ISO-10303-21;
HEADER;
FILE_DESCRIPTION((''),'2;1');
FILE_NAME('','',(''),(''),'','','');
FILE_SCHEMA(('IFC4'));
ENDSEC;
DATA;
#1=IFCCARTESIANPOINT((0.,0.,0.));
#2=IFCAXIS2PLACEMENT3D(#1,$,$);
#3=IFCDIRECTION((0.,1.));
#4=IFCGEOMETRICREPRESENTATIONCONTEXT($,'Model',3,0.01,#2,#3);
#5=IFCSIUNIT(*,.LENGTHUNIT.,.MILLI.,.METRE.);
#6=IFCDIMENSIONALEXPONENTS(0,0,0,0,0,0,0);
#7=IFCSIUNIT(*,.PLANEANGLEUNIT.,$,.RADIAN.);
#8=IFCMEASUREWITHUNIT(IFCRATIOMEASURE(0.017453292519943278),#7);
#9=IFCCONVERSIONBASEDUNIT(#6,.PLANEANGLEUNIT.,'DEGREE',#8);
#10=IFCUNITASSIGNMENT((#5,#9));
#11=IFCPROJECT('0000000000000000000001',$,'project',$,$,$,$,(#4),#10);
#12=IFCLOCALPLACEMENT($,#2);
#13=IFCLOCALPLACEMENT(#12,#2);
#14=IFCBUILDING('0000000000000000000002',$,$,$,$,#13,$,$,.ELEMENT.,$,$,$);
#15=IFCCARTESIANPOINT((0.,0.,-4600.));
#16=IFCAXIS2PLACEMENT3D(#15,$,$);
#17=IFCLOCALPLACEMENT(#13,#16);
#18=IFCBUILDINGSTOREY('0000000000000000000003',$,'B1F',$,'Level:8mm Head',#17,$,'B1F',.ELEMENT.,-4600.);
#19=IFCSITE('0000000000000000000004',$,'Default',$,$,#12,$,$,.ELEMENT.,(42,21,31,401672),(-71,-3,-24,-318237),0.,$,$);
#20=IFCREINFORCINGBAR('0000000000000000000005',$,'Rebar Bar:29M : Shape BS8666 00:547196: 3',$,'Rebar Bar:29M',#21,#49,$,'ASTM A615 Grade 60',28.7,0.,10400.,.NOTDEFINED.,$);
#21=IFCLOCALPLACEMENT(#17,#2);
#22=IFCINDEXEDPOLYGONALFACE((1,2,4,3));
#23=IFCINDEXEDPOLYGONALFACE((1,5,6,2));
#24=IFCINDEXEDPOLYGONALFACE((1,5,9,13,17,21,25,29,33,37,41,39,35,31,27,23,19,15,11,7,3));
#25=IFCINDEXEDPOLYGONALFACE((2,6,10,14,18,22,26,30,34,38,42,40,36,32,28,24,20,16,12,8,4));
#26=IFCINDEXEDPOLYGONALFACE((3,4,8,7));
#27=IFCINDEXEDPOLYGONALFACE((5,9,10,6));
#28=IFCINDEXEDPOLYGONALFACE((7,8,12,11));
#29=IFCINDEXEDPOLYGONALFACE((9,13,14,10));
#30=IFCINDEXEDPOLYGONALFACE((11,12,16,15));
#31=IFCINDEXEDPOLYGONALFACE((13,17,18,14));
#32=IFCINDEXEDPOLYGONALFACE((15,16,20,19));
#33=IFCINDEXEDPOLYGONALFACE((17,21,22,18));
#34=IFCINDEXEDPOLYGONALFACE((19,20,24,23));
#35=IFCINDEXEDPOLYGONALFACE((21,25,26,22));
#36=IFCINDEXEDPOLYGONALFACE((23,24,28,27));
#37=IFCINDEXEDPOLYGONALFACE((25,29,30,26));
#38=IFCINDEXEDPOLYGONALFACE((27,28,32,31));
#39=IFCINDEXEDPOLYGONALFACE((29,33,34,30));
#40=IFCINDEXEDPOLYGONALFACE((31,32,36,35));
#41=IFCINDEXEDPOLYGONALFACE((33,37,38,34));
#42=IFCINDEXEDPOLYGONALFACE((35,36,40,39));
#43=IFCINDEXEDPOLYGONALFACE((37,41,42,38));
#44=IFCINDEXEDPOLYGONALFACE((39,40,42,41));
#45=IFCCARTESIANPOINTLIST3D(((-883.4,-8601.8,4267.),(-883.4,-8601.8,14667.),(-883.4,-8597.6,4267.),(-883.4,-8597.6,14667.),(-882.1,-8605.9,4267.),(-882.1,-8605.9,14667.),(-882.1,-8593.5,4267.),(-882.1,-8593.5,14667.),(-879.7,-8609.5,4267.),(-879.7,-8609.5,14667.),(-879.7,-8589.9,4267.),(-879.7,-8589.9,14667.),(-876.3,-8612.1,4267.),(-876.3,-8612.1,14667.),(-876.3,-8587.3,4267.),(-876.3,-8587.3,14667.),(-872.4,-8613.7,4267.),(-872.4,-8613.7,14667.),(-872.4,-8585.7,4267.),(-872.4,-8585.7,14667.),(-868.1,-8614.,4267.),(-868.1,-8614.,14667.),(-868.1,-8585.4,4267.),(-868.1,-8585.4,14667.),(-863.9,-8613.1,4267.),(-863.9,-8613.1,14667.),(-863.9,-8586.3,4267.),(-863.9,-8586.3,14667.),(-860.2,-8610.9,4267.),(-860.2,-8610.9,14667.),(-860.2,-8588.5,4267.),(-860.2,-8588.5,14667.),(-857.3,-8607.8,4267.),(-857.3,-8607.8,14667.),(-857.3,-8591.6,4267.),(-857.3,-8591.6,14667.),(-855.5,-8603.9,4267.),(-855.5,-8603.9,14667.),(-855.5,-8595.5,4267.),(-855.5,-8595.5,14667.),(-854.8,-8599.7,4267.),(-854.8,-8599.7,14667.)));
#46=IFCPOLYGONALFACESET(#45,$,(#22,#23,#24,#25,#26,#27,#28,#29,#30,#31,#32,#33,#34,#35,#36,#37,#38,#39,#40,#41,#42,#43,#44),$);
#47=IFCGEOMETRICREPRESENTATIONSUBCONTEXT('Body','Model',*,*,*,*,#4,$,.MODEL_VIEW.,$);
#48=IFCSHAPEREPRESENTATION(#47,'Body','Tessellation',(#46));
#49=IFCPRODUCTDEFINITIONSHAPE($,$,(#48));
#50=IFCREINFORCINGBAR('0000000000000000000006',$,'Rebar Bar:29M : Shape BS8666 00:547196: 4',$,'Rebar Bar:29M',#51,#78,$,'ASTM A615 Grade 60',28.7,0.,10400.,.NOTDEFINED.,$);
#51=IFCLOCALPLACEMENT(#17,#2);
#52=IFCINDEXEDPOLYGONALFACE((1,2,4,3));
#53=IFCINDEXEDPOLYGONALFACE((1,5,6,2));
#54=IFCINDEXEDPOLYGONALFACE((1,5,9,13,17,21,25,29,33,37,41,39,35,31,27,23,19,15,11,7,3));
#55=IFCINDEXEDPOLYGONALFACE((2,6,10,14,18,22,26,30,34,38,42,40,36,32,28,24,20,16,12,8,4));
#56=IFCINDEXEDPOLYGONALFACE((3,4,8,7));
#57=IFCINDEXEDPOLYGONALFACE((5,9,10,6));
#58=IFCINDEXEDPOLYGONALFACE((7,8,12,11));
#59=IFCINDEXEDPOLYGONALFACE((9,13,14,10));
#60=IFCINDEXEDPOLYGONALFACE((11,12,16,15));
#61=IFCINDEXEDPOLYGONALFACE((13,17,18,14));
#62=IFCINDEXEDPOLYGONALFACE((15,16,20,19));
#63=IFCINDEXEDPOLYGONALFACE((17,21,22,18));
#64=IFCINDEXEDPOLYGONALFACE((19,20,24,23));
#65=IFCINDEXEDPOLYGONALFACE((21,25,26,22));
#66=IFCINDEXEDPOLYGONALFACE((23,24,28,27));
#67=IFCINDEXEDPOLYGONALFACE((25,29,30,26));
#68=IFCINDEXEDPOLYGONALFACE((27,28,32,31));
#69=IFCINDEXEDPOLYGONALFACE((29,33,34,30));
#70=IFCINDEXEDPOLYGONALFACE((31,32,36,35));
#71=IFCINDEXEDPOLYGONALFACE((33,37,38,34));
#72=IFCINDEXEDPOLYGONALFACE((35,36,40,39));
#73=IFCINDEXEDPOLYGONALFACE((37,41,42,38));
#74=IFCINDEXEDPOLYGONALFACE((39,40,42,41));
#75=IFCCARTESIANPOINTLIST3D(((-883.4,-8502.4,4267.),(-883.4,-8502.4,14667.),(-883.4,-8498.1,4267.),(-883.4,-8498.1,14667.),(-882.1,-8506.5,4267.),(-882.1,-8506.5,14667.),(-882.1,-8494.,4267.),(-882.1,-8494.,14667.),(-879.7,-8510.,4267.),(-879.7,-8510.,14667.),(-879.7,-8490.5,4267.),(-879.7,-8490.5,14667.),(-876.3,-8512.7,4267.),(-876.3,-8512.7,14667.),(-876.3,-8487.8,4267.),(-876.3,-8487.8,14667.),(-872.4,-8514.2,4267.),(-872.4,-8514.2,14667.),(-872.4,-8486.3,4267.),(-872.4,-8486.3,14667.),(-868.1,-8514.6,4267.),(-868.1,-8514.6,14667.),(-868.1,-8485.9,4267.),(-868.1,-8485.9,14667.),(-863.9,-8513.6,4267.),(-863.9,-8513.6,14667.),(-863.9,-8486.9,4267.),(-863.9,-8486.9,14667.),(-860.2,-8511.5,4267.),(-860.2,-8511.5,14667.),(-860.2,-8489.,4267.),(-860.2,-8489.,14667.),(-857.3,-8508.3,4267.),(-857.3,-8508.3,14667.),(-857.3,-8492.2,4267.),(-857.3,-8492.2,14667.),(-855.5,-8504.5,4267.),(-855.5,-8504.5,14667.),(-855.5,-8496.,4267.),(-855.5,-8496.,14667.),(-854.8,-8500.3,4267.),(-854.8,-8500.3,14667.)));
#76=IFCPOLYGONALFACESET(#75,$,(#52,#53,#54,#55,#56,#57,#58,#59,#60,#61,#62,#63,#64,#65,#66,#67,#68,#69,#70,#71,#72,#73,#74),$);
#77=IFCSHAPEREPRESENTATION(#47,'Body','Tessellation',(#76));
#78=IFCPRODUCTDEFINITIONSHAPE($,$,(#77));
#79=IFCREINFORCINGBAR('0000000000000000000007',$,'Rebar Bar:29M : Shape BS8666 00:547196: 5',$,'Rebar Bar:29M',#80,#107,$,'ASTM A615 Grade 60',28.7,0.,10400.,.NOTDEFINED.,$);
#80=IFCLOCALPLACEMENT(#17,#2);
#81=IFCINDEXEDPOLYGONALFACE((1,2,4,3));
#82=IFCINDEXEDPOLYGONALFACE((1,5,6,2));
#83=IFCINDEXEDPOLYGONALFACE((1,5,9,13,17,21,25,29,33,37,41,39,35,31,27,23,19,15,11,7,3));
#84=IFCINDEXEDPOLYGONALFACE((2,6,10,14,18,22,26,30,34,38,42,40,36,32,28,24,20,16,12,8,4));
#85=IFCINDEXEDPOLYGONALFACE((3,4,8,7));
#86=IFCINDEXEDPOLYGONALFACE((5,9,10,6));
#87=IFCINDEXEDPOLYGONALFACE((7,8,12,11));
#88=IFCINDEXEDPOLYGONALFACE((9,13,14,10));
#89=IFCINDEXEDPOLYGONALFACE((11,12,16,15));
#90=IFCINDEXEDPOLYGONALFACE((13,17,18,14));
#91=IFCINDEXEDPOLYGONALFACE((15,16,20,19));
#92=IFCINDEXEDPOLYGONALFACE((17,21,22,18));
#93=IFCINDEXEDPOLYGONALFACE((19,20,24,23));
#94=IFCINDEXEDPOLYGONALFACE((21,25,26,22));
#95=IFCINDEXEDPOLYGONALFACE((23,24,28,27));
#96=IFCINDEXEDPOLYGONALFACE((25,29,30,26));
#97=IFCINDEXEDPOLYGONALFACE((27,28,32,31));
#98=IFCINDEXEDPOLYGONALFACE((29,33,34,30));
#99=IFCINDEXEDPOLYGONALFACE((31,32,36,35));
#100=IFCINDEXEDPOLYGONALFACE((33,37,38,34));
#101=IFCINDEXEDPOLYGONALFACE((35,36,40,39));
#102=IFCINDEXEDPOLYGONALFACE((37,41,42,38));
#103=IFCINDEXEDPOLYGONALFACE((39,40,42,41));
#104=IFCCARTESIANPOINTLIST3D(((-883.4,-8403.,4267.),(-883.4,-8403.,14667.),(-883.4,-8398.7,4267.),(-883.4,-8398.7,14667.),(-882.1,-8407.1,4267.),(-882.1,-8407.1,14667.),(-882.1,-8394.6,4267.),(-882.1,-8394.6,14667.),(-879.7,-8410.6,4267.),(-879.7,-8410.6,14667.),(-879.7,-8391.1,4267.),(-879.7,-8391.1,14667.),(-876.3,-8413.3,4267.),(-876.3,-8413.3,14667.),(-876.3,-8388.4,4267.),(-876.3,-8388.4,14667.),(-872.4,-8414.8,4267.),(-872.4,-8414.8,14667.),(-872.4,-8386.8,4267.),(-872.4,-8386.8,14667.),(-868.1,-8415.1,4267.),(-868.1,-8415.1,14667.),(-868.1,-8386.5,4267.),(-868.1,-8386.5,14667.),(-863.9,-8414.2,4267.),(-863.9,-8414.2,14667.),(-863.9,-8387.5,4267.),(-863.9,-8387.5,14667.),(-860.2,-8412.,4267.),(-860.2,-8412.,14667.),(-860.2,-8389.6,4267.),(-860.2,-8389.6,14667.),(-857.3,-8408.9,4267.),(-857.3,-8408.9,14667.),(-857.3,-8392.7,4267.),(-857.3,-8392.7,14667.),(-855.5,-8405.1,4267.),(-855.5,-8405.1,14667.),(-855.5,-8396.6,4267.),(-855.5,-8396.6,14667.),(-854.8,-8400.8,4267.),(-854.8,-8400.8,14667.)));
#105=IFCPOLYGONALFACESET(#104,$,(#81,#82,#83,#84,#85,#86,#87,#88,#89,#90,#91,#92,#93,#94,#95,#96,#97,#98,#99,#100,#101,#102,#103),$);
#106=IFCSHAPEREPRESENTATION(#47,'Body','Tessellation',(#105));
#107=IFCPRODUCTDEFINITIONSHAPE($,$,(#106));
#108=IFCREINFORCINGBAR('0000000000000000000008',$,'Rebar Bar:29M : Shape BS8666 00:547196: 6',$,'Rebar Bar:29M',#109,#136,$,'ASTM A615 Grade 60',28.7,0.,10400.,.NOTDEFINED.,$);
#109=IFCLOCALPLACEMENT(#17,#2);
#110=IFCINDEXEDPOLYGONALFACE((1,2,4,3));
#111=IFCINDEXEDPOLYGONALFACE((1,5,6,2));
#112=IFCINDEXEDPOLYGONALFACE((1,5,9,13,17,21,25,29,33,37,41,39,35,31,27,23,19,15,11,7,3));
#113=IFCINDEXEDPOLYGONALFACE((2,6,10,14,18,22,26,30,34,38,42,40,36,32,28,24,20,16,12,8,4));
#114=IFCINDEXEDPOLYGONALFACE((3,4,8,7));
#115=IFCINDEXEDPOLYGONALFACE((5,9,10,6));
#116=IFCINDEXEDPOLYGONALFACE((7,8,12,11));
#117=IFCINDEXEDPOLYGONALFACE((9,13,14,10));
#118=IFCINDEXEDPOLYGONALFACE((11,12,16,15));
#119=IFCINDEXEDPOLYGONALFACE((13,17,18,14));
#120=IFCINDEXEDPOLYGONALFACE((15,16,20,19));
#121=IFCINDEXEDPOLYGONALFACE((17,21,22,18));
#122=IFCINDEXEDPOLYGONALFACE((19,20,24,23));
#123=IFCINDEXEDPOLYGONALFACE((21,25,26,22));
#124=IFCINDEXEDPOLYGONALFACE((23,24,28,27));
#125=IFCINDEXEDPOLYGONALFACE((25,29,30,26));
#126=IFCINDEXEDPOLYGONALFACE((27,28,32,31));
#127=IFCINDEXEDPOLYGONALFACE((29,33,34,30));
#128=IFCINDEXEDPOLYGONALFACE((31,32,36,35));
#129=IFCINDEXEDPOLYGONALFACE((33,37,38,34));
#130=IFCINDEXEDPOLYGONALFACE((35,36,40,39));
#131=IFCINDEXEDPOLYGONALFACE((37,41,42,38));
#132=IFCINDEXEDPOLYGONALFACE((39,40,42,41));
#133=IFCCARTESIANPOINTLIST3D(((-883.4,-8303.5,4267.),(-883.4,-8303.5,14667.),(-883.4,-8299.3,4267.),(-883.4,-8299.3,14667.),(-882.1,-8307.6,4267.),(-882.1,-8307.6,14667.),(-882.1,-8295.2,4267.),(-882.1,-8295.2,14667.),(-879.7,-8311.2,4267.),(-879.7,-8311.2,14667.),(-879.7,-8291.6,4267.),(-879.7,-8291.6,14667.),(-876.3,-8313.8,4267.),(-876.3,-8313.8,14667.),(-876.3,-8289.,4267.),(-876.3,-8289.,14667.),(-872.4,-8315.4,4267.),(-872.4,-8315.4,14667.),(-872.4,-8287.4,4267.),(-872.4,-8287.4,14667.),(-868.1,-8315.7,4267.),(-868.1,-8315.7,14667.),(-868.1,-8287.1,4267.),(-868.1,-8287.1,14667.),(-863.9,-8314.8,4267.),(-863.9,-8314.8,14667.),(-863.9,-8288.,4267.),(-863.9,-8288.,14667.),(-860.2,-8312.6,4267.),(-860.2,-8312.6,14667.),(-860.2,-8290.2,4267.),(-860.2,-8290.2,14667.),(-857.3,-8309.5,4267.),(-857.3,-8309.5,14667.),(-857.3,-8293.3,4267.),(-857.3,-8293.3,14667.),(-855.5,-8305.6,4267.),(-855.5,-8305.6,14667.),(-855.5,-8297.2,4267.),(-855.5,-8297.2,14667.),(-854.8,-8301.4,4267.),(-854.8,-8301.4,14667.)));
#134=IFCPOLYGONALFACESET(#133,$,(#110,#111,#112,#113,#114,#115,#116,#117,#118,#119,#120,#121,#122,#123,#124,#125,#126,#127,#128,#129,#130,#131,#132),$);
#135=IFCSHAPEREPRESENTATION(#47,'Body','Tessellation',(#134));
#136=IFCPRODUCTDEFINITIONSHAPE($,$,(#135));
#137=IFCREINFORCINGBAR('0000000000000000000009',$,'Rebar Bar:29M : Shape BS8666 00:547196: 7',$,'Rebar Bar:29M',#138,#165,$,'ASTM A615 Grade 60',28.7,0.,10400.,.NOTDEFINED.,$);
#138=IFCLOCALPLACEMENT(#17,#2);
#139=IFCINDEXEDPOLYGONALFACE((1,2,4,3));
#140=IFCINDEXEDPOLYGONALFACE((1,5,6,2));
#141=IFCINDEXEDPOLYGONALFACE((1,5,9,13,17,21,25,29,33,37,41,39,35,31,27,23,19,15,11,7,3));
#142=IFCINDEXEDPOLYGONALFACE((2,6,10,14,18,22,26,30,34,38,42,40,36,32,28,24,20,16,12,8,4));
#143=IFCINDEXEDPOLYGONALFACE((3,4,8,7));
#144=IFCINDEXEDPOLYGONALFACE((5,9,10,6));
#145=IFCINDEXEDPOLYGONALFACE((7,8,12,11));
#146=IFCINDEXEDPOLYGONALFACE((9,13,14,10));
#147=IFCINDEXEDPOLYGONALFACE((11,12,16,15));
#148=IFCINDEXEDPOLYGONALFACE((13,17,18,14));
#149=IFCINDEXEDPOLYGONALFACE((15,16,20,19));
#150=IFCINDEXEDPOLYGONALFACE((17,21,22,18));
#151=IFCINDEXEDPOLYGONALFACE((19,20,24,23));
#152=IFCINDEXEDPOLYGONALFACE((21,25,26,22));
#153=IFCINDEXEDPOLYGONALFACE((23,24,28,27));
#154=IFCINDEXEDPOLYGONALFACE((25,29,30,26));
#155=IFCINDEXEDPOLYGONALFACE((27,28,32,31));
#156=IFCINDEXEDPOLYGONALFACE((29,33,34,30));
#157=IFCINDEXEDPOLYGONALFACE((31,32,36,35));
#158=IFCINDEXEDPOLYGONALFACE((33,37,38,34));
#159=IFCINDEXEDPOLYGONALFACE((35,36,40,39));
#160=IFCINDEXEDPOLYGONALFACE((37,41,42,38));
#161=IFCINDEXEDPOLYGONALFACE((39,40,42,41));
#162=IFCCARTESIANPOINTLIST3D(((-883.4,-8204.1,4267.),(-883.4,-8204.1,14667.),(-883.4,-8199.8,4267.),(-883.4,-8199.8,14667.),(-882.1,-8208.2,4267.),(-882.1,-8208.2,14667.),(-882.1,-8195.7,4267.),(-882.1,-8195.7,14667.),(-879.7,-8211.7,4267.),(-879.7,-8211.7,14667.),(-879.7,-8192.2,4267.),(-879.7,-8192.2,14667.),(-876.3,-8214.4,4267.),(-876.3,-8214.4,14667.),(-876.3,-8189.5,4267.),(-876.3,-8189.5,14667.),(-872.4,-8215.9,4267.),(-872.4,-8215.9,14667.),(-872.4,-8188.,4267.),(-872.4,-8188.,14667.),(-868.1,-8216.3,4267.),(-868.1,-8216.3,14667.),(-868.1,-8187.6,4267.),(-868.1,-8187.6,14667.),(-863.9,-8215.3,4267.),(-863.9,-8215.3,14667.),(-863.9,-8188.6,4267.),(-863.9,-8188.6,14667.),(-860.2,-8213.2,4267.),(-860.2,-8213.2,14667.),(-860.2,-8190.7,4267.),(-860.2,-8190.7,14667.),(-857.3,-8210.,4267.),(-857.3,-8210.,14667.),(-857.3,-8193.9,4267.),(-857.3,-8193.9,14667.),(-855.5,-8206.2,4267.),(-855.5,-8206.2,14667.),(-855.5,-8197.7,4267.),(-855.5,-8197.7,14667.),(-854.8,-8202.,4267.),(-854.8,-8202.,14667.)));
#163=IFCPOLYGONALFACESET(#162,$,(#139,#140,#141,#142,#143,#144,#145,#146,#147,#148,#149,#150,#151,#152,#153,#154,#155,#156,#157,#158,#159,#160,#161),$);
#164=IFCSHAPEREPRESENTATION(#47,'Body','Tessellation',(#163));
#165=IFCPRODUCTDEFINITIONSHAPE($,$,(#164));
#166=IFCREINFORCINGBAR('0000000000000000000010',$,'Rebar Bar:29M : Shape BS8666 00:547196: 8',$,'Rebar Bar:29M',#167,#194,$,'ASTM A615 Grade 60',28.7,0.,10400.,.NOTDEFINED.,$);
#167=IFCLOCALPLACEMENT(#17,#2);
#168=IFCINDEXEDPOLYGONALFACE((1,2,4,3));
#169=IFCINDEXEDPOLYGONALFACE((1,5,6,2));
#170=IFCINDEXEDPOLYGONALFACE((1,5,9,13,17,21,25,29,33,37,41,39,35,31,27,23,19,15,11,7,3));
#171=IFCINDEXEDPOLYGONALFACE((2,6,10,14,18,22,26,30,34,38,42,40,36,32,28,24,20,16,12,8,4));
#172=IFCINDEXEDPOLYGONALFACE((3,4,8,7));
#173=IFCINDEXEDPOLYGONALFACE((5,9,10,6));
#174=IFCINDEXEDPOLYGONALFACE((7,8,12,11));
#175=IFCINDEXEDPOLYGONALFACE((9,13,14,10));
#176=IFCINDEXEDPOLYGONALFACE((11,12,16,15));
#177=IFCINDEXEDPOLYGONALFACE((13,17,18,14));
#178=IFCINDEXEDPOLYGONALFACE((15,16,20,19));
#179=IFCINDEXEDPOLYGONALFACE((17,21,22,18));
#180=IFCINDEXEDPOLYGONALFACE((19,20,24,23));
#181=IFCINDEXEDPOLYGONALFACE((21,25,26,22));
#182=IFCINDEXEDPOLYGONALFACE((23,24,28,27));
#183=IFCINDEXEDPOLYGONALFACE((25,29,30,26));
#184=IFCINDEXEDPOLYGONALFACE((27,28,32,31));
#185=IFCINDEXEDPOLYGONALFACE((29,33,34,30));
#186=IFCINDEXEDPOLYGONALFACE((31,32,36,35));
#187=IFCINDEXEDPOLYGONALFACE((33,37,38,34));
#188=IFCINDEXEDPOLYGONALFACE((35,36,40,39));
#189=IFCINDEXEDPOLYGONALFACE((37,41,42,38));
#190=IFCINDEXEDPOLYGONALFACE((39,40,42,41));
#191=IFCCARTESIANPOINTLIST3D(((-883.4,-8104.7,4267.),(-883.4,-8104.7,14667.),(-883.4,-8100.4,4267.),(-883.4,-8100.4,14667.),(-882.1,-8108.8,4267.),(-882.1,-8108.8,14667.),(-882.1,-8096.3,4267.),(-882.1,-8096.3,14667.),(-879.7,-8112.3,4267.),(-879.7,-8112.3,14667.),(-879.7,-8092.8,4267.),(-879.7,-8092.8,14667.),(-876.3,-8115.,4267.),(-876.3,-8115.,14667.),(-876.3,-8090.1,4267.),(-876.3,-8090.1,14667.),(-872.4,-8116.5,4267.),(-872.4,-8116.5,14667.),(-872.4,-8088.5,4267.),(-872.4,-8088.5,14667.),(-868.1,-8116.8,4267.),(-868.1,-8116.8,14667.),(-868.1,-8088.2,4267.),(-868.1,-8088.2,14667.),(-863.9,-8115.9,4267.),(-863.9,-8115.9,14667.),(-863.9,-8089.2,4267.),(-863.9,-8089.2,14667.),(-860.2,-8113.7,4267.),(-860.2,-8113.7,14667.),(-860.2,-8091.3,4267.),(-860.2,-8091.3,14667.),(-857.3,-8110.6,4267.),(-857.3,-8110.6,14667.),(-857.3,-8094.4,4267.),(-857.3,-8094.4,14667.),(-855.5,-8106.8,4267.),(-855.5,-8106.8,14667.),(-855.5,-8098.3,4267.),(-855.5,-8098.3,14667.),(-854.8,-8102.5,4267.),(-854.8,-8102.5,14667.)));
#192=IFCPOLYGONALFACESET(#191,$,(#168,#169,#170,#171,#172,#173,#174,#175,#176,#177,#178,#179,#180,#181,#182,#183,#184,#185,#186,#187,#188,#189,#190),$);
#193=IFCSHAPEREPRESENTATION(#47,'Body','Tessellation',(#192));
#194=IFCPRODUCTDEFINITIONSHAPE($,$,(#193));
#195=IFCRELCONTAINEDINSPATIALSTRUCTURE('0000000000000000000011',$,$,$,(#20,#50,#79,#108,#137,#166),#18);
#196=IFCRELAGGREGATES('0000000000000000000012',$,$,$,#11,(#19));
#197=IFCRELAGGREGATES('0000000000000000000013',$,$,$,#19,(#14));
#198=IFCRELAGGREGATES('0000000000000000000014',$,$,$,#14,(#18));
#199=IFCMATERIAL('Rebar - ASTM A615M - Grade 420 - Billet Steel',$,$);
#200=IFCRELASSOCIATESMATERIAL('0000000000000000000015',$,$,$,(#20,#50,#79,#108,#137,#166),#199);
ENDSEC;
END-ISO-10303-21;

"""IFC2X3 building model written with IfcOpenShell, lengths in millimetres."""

from ifc_helpers import new_model, entity, si_unit, converted_unit, direction, frame, origin, place, context, subcontext, project, spatial, material, element, save


model = new_model("IFC2X3")

# Units and contexts
model_context = context("Model", 3, precision=0.01, world=origin(), true_north=direction((0.0, 1.0)))
body_context = subcontext(model_context, "Body", "Model", "MODEL_VIEW")
ifc_project = project(units=[si_unit("LENGTHUNIT", "METRE", prefix="MILLI"), converted_unit("PLANEANGLEUNIT", "DEGREE", entity("IfcRatioMeasure", 0.017453292519943278), si_unit("PLANEANGLEUNIT", "RADIAN"), dimensions=[0, 0, 0, 0, 0, 0, 0])], contexts=[model_context])

# Site, building, storey
site_placement = place(None, origin())
site = spatial("IfcSite", under=ifc_project, at=site_placement, Name="Default", CompositionType="ELEMENT", RefLatitude=(42, 21, 31, 401672), RefLongitude=(-71, -3, -24, -318237), RefElevation=0.0)
building_placement = place(site_placement, origin())
building = spatial("IfcBuilding", under=site, at=building_placement, CompositionType="ELEMENT")
storey_placement = place(building_placement, frame((0.0, 0.0, -4600.0)))
storey = spatial("IfcBuildingStorey", under=building, at=storey_placement, Name="B1F", ObjectType="Level:8mm Head", LongName="B1F", CompositionType="ELEMENT", Elevation=-4600.0)

# Reinforcing bars
ifc_material = material(Name="Rebar - ASTM A615M - Grade 420 - Billet Steel")
reinforcing_bar_1_placement = place(storey_placement, origin())
element("IfcReinforcingBar", 1, at=reinforcing_bar_1_placement, inside=storey, material=ifc_material, Name="Rebar Bar:29M : Shape BS8666 00:547196: 3", SteelGrade="ASTM A615 Grade 60", ObjectType="Rebar Bar:29M", BarLength=10400.0, BarRole="NOTDEFINED", CrossSectionArea=0.0, NominalDiameter=28.7, context=body_context, shape_type="AdvancedSweptSolid", body=[
    entity("IfcSweptDiskSolid", entity("IfcCompositeCurve", [entity("IfcCompositeCurveSegment", "CONTINUOUS", True, entity("IfcPolyline", [entity("IfcCartesianPoint", [-869.2, -8599.7, 4267.0]), entity("IfcCartesianPoint", [-869.2, -8599.7, 14667.0])]))], False), 14.3, None, 0.0, 1.0),
])
reinforcing_bar_2_placement = place(storey_placement, origin())
element("IfcReinforcingBar", 2, at=reinforcing_bar_2_placement, inside=storey, material=ifc_material, Name="Rebar Bar:29M : Shape BS8666 00:547196: 4", SteelGrade="ASTM A615 Grade 60", ObjectType="Rebar Bar:29M", BarLength=10400.0, BarRole="NOTDEFINED", CrossSectionArea=0.0, NominalDiameter=28.7, context=body_context, shape_type="AdvancedSweptSolid", body=[
    entity("IfcSweptDiskSolid", entity("IfcCompositeCurve", [entity("IfcCompositeCurveSegment", "CONTINUOUS", True, entity("IfcPolyline", [entity("IfcCartesianPoint", [-869.2, -8500.3, 4267.0]), entity("IfcCartesianPoint", [-869.2, -8500.3, 14667.0])]))], False), 14.3, None, 0.0, 1.0),
])
reinforcing_bar_3_placement = place(storey_placement, origin())
element("IfcReinforcingBar", 3, at=reinforcing_bar_3_placement, inside=storey, material=ifc_material, Name="Rebar Bar:29M : Shape BS8666 00:547196: 5", SteelGrade="ASTM A615 Grade 60", ObjectType="Rebar Bar:29M", BarLength=10400.0, BarRole="NOTDEFINED", CrossSectionArea=0.0, NominalDiameter=28.7, context=body_context, shape_type="AdvancedSweptSolid", body=[
    entity("IfcSweptDiskSolid", entity("IfcCompositeCurve", [entity("IfcCompositeCurveSegment", "CONTINUOUS", True, entity("IfcPolyline", [entity("IfcCartesianPoint", [-869.2, -8400.8, 4267.0]), entity("IfcCartesianPoint", [-869.2, -8400.8, 14667.0])]))], False), 14.3, None, 0.0, 1.0),
])
reinforcing_bar_4_placement = place(storey_placement, origin())
element("IfcReinforcingBar", 4, at=reinforcing_bar_4_placement, inside=storey, material=ifc_material, Name="Rebar Bar:29M : Shape BS8666 00:547196: 6", SteelGrade="ASTM A615 Grade 60", ObjectType="Rebar Bar:29M", BarLength=10400.0, BarRole="NOTDEFINED", CrossSectionArea=0.0, NominalDiameter=28.7, context=body_context, shape_type="AdvancedSweptSolid", body=[
    entity("IfcSweptDiskSolid", entity("IfcCompositeCurve", [entity("IfcCompositeCurveSegment", "CONTINUOUS", True, entity("IfcPolyline", [entity("IfcCartesianPoint", [-869.2, -8301.4, 4267.0]), entity("IfcCartesianPoint", [-869.2, -8301.4, 14667.0])]))], False), 14.3, None, 0.0, 1.0),
])
reinforcing_bar_5_placement = place(storey_placement, origin())
element("IfcReinforcingBar", 5, at=reinforcing_bar_5_placement, inside=storey, material=ifc_material, Name="Rebar Bar:29M : Shape BS8666 00:547196: 7", SteelGrade="ASTM A615 Grade 60", ObjectType="Rebar Bar:29M", BarLength=10400.0, BarRole="NOTDEFINED", CrossSectionArea=0.0, NominalDiameter=28.7, context=body_context, shape_type="AdvancedSweptSolid", body=[
    entity("IfcSweptDiskSolid", entity("IfcCompositeCurve", [entity("IfcCompositeCurveSegment", "CONTINUOUS", True, entity("IfcPolyline", [entity("IfcCartesianPoint", [-869.2, -8202.0, 4267.0]), entity("IfcCartesianPoint", [-869.2, -8202.0, 14667.0])]))], False), 14.3, None, 0.0, 1.0),
])
reinforcing_bar_6_placement = place(storey_placement, origin())
element("IfcReinforcingBar", 6, at=reinforcing_bar_6_placement, inside=storey, material=ifc_material, Name="Rebar Bar:29M : Shape BS8666 00:547196: 8", SteelGrade="ASTM A615 Grade 60", ObjectType="Rebar Bar:29M", BarLength=10400.0, BarRole="NOTDEFINED", CrossSectionArea=0.0, NominalDiameter=28.7, context=body_context, shape_type="AdvancedSweptSolid", body=[
    entity("IfcSweptDiskSolid", entity("IfcCompositeCurve", [entity("IfcCompositeCurveSegment", "CONTINUOUS", True, entity("IfcPolyline", [entity("IfcCartesianPoint", [-869.2, -8102.5, 4267.0]), entity("IfcCartesianPoint", [-869.2, -8102.5, 14667.0])]))], False), 14.3, None, 0.0, 1.0),
])

save(model, "model.ifc")
